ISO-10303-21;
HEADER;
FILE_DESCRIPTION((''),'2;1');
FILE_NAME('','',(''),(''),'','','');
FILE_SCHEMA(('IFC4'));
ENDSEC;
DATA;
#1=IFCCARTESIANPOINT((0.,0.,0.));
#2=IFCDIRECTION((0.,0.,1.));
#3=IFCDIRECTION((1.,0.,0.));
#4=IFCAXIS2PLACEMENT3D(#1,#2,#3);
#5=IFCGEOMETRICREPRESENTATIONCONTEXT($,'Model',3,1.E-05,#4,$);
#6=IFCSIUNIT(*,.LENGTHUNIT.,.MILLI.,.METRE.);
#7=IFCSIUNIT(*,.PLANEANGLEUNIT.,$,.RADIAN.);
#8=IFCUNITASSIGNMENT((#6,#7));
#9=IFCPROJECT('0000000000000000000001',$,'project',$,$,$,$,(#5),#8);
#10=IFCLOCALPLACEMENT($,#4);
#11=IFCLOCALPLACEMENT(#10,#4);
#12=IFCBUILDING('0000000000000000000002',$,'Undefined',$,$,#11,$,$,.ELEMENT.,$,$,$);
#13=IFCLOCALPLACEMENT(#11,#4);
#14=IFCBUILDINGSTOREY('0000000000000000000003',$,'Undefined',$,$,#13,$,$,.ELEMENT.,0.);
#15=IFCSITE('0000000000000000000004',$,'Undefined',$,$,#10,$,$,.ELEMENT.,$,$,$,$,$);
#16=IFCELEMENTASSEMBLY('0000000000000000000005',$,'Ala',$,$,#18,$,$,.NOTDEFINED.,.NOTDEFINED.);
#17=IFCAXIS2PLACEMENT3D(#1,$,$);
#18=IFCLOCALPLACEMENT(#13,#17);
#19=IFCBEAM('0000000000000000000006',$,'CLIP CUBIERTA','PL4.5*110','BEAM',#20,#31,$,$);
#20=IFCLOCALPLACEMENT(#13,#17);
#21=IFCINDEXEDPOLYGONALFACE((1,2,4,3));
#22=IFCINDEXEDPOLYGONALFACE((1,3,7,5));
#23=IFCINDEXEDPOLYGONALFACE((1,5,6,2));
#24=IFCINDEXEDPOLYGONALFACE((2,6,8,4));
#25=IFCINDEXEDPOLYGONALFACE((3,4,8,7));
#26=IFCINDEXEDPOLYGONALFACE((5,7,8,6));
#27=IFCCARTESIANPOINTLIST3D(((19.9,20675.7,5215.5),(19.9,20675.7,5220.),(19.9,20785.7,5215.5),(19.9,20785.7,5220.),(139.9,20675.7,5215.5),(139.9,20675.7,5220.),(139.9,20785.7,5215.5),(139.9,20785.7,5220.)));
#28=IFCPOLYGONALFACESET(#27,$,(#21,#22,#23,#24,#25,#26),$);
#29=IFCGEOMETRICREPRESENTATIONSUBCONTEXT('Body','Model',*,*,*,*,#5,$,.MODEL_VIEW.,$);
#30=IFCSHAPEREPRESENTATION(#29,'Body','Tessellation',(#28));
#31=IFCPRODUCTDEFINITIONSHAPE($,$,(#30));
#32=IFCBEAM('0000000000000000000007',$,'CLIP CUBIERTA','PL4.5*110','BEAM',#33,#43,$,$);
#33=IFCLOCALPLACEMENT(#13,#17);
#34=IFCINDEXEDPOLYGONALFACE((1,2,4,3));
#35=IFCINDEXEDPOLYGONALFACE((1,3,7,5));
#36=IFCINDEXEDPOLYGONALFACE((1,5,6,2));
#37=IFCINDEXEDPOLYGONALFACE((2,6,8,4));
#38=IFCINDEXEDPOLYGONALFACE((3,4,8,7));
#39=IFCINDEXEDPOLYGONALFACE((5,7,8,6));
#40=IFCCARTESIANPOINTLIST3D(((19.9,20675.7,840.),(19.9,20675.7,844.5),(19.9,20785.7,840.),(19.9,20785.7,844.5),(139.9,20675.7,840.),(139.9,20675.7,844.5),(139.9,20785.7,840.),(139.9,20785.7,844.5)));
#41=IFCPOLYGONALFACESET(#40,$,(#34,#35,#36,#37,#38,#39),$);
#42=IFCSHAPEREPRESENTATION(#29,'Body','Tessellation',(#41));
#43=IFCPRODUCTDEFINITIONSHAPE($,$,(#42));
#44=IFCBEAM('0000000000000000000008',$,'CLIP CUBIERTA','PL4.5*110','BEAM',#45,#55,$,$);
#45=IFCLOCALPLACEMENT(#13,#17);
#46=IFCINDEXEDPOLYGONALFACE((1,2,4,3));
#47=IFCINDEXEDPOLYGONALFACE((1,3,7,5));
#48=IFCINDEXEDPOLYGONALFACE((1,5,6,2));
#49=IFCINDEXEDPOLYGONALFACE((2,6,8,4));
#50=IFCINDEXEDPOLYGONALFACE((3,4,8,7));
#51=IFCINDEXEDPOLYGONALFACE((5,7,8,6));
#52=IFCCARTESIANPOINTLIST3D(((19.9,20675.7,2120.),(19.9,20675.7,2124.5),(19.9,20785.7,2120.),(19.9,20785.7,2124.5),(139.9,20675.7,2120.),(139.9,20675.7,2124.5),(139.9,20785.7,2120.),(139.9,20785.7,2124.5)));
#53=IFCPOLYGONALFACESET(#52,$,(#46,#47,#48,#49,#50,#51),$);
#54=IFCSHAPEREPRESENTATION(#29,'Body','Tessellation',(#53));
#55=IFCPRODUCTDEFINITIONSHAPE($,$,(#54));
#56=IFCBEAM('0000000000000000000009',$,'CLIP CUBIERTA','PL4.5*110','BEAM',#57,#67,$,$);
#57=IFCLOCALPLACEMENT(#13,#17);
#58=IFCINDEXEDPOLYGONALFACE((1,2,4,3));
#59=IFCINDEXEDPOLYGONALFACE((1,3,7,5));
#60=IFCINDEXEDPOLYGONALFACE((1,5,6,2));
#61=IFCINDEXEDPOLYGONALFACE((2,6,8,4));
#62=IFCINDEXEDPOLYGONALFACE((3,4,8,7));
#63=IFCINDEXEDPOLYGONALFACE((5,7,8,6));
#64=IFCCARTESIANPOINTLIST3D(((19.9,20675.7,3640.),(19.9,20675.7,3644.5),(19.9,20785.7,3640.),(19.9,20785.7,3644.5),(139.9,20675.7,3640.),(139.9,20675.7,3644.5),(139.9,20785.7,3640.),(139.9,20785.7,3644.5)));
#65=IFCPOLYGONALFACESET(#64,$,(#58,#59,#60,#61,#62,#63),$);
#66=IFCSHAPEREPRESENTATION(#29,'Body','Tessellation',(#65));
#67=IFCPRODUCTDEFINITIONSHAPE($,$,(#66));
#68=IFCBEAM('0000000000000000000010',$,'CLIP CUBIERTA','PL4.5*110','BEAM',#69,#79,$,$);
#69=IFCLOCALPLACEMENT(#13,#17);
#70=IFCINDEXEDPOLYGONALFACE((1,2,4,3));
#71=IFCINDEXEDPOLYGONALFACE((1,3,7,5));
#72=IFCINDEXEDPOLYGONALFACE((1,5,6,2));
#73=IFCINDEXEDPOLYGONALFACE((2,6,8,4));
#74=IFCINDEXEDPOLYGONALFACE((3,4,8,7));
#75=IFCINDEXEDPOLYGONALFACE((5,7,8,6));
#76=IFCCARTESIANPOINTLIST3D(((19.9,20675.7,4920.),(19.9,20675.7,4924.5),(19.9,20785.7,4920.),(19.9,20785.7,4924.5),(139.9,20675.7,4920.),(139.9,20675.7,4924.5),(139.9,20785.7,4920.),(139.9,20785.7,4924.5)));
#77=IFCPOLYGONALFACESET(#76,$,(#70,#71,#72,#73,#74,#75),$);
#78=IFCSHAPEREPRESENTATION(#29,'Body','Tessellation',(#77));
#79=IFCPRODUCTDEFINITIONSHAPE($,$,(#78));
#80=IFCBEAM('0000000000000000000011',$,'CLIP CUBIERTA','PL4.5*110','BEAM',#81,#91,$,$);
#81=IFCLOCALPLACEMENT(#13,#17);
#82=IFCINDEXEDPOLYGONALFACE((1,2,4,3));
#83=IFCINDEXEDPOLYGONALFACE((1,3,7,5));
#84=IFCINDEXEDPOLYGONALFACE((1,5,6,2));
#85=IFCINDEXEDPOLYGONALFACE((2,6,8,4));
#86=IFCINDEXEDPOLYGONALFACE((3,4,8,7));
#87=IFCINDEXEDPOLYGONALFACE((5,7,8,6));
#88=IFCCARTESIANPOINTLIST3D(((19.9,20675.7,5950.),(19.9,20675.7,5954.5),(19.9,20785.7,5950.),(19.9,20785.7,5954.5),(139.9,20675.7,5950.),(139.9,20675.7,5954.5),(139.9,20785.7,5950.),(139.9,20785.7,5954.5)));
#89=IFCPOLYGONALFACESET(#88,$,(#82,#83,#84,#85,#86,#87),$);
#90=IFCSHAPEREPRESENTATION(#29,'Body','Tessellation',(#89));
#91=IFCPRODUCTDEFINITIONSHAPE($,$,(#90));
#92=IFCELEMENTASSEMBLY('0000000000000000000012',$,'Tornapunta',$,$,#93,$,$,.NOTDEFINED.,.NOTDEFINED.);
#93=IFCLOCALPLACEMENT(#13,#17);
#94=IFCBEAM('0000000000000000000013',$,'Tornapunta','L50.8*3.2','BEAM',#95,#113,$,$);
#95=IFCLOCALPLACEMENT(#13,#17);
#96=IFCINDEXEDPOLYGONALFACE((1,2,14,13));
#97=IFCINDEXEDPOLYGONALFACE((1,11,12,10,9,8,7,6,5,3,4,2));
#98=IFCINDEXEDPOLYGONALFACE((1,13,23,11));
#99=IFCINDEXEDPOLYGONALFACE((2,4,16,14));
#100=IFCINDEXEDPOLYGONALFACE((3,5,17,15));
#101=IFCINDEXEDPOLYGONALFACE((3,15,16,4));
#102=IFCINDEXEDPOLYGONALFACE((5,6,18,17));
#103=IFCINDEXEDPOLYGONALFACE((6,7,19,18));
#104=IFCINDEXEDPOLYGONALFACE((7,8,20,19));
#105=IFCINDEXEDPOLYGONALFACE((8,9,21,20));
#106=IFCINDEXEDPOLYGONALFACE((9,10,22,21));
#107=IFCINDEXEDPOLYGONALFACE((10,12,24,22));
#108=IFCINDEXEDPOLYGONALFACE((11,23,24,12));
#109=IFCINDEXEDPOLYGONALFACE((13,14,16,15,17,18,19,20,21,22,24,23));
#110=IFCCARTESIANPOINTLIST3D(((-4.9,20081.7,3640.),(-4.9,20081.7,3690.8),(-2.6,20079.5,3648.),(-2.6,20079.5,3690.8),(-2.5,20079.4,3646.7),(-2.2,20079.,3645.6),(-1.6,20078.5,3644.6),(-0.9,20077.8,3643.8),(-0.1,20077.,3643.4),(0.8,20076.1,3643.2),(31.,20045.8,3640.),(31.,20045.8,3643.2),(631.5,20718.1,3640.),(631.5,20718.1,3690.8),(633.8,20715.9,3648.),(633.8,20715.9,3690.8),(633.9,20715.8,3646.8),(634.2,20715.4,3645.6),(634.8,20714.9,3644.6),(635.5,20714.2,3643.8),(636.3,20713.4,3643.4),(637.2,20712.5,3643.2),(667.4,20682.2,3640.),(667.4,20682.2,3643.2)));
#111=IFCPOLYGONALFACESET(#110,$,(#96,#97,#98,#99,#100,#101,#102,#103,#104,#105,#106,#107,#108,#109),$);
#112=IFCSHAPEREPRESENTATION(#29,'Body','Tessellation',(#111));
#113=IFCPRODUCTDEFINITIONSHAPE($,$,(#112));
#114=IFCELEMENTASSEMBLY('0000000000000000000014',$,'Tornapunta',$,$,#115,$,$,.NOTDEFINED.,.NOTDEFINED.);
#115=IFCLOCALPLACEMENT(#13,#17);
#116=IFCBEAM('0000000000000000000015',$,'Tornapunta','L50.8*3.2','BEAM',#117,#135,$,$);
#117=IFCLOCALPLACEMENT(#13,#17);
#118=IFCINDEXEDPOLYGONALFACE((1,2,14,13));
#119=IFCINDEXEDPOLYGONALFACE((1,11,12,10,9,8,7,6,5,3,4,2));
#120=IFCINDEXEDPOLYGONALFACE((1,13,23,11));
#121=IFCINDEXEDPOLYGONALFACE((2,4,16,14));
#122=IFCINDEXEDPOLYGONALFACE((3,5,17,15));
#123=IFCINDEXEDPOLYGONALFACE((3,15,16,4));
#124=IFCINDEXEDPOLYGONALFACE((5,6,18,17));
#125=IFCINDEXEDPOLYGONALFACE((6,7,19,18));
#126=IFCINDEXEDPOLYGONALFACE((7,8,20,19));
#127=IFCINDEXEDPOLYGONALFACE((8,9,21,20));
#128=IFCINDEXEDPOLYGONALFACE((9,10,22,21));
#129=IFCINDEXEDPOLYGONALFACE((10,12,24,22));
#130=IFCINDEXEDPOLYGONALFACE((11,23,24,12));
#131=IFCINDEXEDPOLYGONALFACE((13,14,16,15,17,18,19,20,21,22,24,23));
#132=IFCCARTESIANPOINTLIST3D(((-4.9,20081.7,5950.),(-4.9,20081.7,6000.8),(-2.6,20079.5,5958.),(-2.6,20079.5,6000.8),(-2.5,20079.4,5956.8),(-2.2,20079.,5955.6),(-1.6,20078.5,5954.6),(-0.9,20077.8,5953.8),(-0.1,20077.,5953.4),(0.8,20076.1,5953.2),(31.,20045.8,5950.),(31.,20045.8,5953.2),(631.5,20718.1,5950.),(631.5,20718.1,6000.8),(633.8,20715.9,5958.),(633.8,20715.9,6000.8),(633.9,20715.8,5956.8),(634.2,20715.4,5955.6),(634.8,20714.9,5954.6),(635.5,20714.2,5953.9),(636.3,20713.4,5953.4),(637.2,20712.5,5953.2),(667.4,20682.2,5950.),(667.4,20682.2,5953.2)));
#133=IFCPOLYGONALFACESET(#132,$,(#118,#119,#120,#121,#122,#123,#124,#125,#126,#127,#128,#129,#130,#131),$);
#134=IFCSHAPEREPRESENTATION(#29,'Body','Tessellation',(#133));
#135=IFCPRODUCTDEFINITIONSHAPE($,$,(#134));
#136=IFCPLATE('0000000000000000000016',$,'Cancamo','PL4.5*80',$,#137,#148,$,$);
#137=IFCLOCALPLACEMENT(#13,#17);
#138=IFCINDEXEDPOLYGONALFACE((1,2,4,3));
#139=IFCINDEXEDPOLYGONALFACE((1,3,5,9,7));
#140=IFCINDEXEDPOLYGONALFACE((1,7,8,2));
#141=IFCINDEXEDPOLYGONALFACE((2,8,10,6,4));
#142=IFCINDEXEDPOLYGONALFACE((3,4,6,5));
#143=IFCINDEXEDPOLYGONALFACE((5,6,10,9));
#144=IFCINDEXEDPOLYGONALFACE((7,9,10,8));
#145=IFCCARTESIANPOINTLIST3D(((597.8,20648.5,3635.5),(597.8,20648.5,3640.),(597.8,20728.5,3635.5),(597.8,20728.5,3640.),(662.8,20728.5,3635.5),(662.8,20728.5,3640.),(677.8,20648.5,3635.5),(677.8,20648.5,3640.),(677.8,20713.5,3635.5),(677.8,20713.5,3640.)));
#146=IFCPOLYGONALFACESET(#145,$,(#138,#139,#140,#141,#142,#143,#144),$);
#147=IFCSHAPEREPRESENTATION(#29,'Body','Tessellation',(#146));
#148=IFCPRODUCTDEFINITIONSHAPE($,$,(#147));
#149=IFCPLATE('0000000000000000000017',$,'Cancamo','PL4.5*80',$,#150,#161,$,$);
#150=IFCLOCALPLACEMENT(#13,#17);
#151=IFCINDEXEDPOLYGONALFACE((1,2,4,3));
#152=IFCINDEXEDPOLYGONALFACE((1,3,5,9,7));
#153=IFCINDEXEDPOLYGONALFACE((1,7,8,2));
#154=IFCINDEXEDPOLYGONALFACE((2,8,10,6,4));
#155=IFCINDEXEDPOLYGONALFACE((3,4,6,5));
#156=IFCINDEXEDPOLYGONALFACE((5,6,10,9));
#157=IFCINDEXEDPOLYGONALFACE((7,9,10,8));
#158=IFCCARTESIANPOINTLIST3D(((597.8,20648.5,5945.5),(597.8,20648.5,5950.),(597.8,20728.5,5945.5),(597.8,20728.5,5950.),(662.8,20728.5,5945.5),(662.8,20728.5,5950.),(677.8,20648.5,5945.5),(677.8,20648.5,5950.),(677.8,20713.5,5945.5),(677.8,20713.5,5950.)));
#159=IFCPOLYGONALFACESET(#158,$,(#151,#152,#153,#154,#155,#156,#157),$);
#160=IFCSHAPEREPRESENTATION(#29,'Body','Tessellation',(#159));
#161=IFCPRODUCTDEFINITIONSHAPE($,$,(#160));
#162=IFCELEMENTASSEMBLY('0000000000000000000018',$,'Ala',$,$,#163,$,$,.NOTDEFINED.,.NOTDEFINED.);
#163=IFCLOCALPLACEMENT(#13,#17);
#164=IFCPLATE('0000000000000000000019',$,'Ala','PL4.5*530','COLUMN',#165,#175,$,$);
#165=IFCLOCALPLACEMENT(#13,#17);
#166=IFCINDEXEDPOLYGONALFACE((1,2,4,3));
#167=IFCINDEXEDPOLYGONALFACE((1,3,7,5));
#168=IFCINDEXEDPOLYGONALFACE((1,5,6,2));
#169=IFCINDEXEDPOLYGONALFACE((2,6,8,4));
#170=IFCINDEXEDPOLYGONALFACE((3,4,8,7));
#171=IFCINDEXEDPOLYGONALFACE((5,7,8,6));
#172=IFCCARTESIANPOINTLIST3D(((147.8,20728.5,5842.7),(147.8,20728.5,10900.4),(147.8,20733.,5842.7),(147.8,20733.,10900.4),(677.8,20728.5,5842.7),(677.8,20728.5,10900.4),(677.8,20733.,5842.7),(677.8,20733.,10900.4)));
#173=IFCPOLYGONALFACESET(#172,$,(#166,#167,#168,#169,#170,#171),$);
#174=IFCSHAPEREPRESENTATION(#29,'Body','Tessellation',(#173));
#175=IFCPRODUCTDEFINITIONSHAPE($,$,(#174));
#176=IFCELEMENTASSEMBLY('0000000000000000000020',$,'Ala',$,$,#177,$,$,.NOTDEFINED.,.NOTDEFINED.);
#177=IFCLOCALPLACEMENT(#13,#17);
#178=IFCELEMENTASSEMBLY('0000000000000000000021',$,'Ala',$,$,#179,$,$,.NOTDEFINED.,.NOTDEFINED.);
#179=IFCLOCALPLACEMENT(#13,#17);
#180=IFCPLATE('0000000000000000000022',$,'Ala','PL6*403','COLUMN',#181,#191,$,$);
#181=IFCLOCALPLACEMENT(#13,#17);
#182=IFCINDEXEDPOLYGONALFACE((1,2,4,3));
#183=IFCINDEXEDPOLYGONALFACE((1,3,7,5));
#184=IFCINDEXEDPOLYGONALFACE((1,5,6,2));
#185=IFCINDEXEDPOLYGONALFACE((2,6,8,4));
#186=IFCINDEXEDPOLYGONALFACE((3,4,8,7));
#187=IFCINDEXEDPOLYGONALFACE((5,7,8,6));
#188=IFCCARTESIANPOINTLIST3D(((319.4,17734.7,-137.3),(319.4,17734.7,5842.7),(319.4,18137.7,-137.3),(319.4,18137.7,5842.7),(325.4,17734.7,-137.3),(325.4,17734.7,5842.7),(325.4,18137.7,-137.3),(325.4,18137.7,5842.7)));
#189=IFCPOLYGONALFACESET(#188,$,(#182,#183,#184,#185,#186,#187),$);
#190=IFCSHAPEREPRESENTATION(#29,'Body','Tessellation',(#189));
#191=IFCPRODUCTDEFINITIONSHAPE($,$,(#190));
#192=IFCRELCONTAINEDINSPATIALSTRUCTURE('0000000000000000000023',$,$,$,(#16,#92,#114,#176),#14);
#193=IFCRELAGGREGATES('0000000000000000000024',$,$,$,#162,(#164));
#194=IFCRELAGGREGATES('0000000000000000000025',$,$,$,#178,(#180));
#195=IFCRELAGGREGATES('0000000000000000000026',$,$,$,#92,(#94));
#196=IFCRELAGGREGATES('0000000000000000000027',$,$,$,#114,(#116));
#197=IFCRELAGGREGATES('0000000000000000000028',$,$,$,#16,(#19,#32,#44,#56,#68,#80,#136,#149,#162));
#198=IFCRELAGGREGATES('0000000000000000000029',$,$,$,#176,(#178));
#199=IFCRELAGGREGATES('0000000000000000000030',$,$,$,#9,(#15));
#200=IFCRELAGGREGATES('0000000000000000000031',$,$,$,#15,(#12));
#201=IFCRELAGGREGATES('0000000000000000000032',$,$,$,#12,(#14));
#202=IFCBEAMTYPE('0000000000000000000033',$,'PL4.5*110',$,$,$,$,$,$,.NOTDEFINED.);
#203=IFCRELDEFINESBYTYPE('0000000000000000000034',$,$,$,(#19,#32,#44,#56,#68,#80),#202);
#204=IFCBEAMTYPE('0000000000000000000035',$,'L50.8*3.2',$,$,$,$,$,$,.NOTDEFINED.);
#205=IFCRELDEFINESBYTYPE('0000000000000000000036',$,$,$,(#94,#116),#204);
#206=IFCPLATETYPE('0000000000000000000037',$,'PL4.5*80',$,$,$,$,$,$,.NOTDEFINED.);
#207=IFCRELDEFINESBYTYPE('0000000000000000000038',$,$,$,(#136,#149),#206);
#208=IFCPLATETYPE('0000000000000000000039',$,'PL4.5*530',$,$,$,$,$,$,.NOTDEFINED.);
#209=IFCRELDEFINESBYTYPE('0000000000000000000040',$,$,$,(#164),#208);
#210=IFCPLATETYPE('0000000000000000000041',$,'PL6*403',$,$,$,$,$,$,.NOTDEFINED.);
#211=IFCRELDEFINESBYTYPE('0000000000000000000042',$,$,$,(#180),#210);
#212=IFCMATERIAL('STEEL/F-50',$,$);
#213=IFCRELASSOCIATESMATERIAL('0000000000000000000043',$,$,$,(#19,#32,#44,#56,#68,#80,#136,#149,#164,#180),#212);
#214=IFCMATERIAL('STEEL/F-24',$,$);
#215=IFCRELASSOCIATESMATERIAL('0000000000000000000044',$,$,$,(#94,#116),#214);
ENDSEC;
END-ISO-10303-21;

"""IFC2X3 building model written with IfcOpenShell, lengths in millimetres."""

from ifc_helpers import new_model, si_unit, frame, origin_with_axes, origin_2d_with_axis, place, context, subcontext, project, spatial, polyline, rectangle, l_section, outline, extrude, material, type_object, element, aggregate, save


model = new_model("IFC2X3")

# Units and contexts
model_context = context("Model", 3, precision=1e-05, world=origin_with_axes())
body_context = subcontext(model_context, "Body", "Model", "MODEL_VIEW")
ifc_project = project(units=[si_unit("LENGTHUNIT", "METRE", prefix="MILLI"), si_unit("PLANEANGLEUNIT", "RADIAN")], contexts=[model_context])

# Site, building, storey
site_placement = place(None, origin_with_axes())
site = spatial("IfcSite", under=ifc_project, at=site_placement, Name="Undefined", CompositionType="ELEMENT")
building_placement = place(site_placement, origin_with_axes())
building = spatial("IfcBuilding", under=site, at=building_placement, Name="Undefined", CompositionType="ELEMENT")
storey_placement = place(building_placement, origin_with_axes())
storey = spatial("IfcBuildingStorey", under=building, at=storey_placement, Name="Undefined", CompositionType="ELEMENT", Elevation=0.0)

# Element assembly, beams
assembly_1_placement = place(storey_placement, origin_with_axes())
assembly_1 = element("IfcElementAssembly", 1, at=assembly_1_placement, inside=storey, Name="Ala", AssemblyPlace="NOTDEFINED", PredefinedType="NOTDEFINED")
ifc_material_1 = material(Name="STEEL/F-50")
beam_type_1 = type_object("IfcBeamType", Name="PL4.5*110", PredefinedType="NOTDEFINED")
beam_1_placement = place(assembly_1_placement, frame((139.9, 20730.7, 5217.7), z_axis=(0.0, 1.0, 0.0), x_axis=(-1.0, 0.0, 0.0)))
beam_1 = element("IfcBeam", 2, at=beam_1_placement, type_object=beam_type_1, material=ifc_material_1, Name="CLIP CUBIERTA", Description="PL4.5*110", ObjectType="BEAM", context=body_context, shape_type="SweptSolid", body=[
    extrude(rectangle(XDim=4.5, YDim=110.0, at=origin_2d_with_axis()), frame((120.0, 0.0, 0.0), z_axis=(-1.0, 0.0, 0.0), x_axis=(0.0, -1.0, 0.0)), (0.0, 0.0, 1.0), 120.0),
])
beam_2_placement = place(assembly_1_placement, frame((139.9, 20730.7, 842.3), z_axis=(0.0, 1.0, 0.0), x_axis=(-1.0, 0.0, 0.0)))
beam_2 = element("IfcBeam", 3, at=beam_2_placement, type_object=beam_type_1, material=ifc_material_1, Name="CLIP CUBIERTA", Description="PL4.5*110", ObjectType="BEAM", context=body_context, shape_type="SweptSolid", body=[
    extrude(rectangle(XDim=4.5, YDim=110.0, at=origin_2d_with_axis()), frame((120.0, 0.0, 0.0), z_axis=(-1.0, 0.0, 0.0), x_axis=(0.0, -1.0, 0.0)), (0.0, 0.0, 1.0), 120.0),
])
beam_3_placement = place(assembly_1_placement, frame((139.9, 20730.7, 2122.3), z_axis=(0.0, 1.0, 0.0), x_axis=(-1.0, 0.0, 0.0)))
beam_3 = element("IfcBeam", 4, at=beam_3_placement, type_object=beam_type_1, material=ifc_material_1, Name="CLIP CUBIERTA", Description="PL4.5*110", ObjectType="BEAM", context=body_context, shape_type="SweptSolid", body=[
    extrude(rectangle(XDim=4.5, YDim=110.0, at=origin_2d_with_axis()), frame((120.0, 0.0, 0.0), z_axis=(-1.0, 0.0, 0.0), x_axis=(0.0, -1.0, 0.0)), (0.0, 0.0, 1.0), 120.0),
])
beam_4_placement = place(assembly_1_placement, frame((139.9, 20730.7, 3642.3), z_axis=(0.0, 1.0, 0.0), x_axis=(-1.0, 0.0, 0.0)))
beam_4 = element("IfcBeam", 5, at=beam_4_placement, type_object=beam_type_1, material=ifc_material_1, Name="CLIP CUBIERTA", Description="PL4.5*110", ObjectType="BEAM", context=body_context, shape_type="SweptSolid", body=[
    extrude(rectangle(XDim=4.5, YDim=110.0, at=origin_2d_with_axis()), frame((120.0, 0.0, 0.0), z_axis=(-1.0, 0.0, 0.0), x_axis=(0.0, -1.0, 0.0)), (0.0, 0.0, 1.0), 120.0),
])
beam_5_placement = place(assembly_1_placement, frame((139.9, 20730.7, 4922.2), z_axis=(0.0, 1.0, 0.0), x_axis=(-1.0, 0.0, 0.0)))
beam_5 = element("IfcBeam", 6, at=beam_5_placement, type_object=beam_type_1, material=ifc_material_1, Name="CLIP CUBIERTA", Description="PL4.5*110", ObjectType="BEAM", context=body_context, shape_type="SweptSolid", body=[
    extrude(rectangle(XDim=4.5, YDim=110.0, at=origin_2d_with_axis()), frame((120.0, 0.0, 0.0), z_axis=(-1.0, 0.0, 0.0), x_axis=(0.0, -1.0, 0.0)), (0.0, 0.0, 1.0), 120.0),
])
beam_6_placement = place(assembly_1_placement, frame((139.9, 20730.7, 5952.3), z_axis=(0.0, 1.0, 0.0), x_axis=(-1.0, 0.0, 0.0)))
beam_6 = element("IfcBeam", 7, at=beam_6_placement, type_object=beam_type_1, material=ifc_material_1, Name="CLIP CUBIERTA", Description="PL4.5*110", ObjectType="BEAM", context=body_context, shape_type="SweptSolid", body=[
    extrude(rectangle(XDim=4.5, YDim=110.0, at=origin_2d_with_axis()), frame((120.0, 0.0, 0.0), z_axis=(-1.0, 0.0, 0.0), x_axis=(0.0, -1.0, 0.0)), (0.0, 0.0, 1.0), 120.0),
])

# Element assemblies, beams
assembly_2_placement = place(storey_placement, origin_with_axes())
assembly_2 = element("IfcElementAssembly", 8, at=assembly_2_placement, inside=storey, Name="Tornapunta", AssemblyPlace="NOTDEFINED", PredefinedType="NOTDEFINED")
ifc_material_2 = material(Name="STEEL/F-24")
beam_type_2 = type_object("IfcBeamType", Name="L50.8*3.2", PredefinedType="NOTDEFINED")
beam_7_placement = place(assembly_2_placement, frame((649.5, 20700.2, 3665.4), z_axis=(0.707107, -0.707107, 0.000016), x_axis=(-0.707107, -0.707107, -0.000016)))
beam_7 = element("IfcBeam", 9, at=beam_7_placement, type_object=beam_type_2, material=ifc_material_2, Name="Tornapunta", Description="L50.8*3.2", ObjectType="BEAM", context=body_context, shape_type="SweptSolid", body=[
    extrude(l_section(Depth=50.8, Width=50.8, Thickness=3.2, FilletRadius=4.8, at=origin_2d_with_axis()), frame((900.0, 0.0, 0.0), z_axis=(-1.0, 0.0, 0.0), x_axis=(0.0, -1.0, 0.0)), (0.0, 0.0, 1.0), 900.0),
])
assembly_3_placement = place(storey_placement, origin_with_axes())
assembly_3 = element("IfcElementAssembly", 10, at=assembly_3_placement, inside=storey, Name="Tornapunta", AssemblyPlace="NOTDEFINED", PredefinedType="NOTDEFINED")
beam_8_placement = place(assembly_3_placement, frame((649.5, 20700.2, 5975.4), z_axis=(0.707107, -0.707107, 0.000016), x_axis=(-0.707107, -0.707107, -0.000016)))
beam_8 = element("IfcBeam", 11, at=beam_8_placement, type_object=beam_type_2, material=ifc_material_2, Name="Tornapunta", Description="L50.8*3.2", ObjectType="BEAM", context=body_context, shape_type="SweptSolid", body=[
    extrude(l_section(Depth=50.8, Width=50.8, Thickness=3.2, FilletRadius=4.8, at=origin_2d_with_axis()), frame((900.0, 0.0, 0.0), z_axis=(-1.0, 0.0, 0.0), x_axis=(0.0, -1.0, 0.0)), (0.0, 0.0, 1.0), 900.0),
])

# Plates
plate_type_1 = type_object("IfcPlateType", Name="PL4.5*80", PredefinedType="NOTDEFINED")
plate_1_placement = place(assembly_1_placement, frame((677.8, 20648.5, 3637.7), z_axis=(-0.000023, 0.0, 1.0), x_axis=(0.0, 1.0, 0.0)))
plate_1 = element("IfcPlate", 12, at=plate_1_placement, type_object=plate_type_1, material=ifc_material_1, Name="Cancamo", Description="PL4.5*80", context=body_context, shape_type="SweptSolid", body=[
    extrude(outline(polyline([(0.0, 0.0), (65.0, 0.0), (80.0, 15.0), (80.0, 80.0), (0.0, 80.0), (0.0, 0.0)])), frame((0.0, 0.0, -2.2), z_axis=(0.0, 0.0, 1.0), x_axis=(1.0, 0.0, 0.0)), (0.0, 0.0, 1.0), 4.5),
])
plate_2_placement = place(assembly_1_placement, frame((677.8, 20648.5, 5947.8), z_axis=(-0.000023, 0.0, 1.0), x_axis=(0.0, 1.0, 0.0)))
plate_2 = element("IfcPlate", 13, at=plate_2_placement, type_object=plate_type_1, material=ifc_material_1, Name="Cancamo", Description="PL4.5*80", context=body_context, shape_type="SweptSolid", body=[
    extrude(outline(polyline([(0.0, 0.0), (65.0, 0.0), (80.0, 15.0), (80.0, 80.0), (0.0, 80.0), (0.0, 0.0)])), frame((0.0, 0.0, -2.2), z_axis=(0.0, 0.0, 1.0), x_axis=(1.0, 0.0, 0.0)), (0.0, 0.0, 1.0), 4.5),
])

# Element assembly, plate
assembly_4_placement = place(assembly_1_placement, origin_with_axes())
assembly_4 = element("IfcElementAssembly", 14, at=assembly_4_placement, Name="Ala", AssemblyPlace="NOTDEFINED", PredefinedType="NOTDEFINED")
plate_type_2 = type_object("IfcPlateType", Name="PL4.5*530", PredefinedType="NOTDEFINED")
plate_3_placement = place(assembly_4_placement, frame((412.8, 20730.7, 5842.7), z_axis=(0.0, 1.0, 0.0), x_axis=(0.0, 0.0, 1.0)))
plate_3 = element("IfcPlate", 15, at=plate_3_placement, type_object=plate_type_2, material=ifc_material_1, Name="Ala", Description="PL4.5*530", ObjectType="COLUMN", context=body_context, shape_type="SweptSolid", body=[
    extrude(outline(polyline([(0.0, -265.0), (0.0, 265.0), (5057.7, 265.0), (5057.7, -265.0), (0.0, -265.0)])), frame((0.0, 0.0, -2.2), z_axis=(0.0, 0.0, 1.0), x_axis=(1.0, 0.0, 0.0)), (0.0, 0.0, 1.0), 4.5),
])
aggregate(assembly_4, [plate_3])

# Element assemblies, plate
assembly_5_placement = place(storey_placement, origin_with_axes())
assembly_5 = element("IfcElementAssembly", 16, at=assembly_5_placement, inside=storey, Name="Ala", AssemblyPlace="NOTDEFINED", PredefinedType="NOTDEFINED")
assembly_6_placement = place(assembly_5_placement, origin_with_axes())
assembly_6 = element("IfcElementAssembly", 17, at=assembly_6_placement, Name="Ala", AssemblyPlace="NOTDEFINED", PredefinedType="NOTDEFINED")
plate_type_3 = type_object("IfcPlateType", Name="PL6*403", PredefinedType="NOTDEFINED")
plate_4_placement = place(assembly_6_placement, frame((322.4, 17936.2, -137.3), z_axis=(-1.0, 0.0, 0.0), x_axis=(0.0, 0.0, 1.0)))
plate_4 = element("IfcPlate", 18, at=plate_4_placement, type_object=plate_type_3, material=ifc_material_1, Name="Ala", Description="PL6*403", ObjectType="COLUMN", context=body_context, shape_type="SweptSolid", body=[
    extrude(outline(polyline([(0.0, -201.5), (0.0, 201.5), (5980.0, 201.5), (5980.0, -201.5), (0.0, -201.5)])), frame((0.0, 0.0, -3.0), z_axis=(0.0, 0.0, 1.0), x_axis=(1.0, 0.0, 0.0)), (0.0, 0.0, 1.0), 6.0),
])

aggregate(assembly_6, [plate_4])

aggregate(assembly_2, [beam_7])
aggregate(assembly_3, [beam_8])
aggregate(assembly_1, [beam_1, beam_2, beam_3, beam_4, beam_5, beam_6, plate_1, plate_2, assembly_4])
aggregate(assembly_5, [assembly_6])

save(model, "model.ifc")
